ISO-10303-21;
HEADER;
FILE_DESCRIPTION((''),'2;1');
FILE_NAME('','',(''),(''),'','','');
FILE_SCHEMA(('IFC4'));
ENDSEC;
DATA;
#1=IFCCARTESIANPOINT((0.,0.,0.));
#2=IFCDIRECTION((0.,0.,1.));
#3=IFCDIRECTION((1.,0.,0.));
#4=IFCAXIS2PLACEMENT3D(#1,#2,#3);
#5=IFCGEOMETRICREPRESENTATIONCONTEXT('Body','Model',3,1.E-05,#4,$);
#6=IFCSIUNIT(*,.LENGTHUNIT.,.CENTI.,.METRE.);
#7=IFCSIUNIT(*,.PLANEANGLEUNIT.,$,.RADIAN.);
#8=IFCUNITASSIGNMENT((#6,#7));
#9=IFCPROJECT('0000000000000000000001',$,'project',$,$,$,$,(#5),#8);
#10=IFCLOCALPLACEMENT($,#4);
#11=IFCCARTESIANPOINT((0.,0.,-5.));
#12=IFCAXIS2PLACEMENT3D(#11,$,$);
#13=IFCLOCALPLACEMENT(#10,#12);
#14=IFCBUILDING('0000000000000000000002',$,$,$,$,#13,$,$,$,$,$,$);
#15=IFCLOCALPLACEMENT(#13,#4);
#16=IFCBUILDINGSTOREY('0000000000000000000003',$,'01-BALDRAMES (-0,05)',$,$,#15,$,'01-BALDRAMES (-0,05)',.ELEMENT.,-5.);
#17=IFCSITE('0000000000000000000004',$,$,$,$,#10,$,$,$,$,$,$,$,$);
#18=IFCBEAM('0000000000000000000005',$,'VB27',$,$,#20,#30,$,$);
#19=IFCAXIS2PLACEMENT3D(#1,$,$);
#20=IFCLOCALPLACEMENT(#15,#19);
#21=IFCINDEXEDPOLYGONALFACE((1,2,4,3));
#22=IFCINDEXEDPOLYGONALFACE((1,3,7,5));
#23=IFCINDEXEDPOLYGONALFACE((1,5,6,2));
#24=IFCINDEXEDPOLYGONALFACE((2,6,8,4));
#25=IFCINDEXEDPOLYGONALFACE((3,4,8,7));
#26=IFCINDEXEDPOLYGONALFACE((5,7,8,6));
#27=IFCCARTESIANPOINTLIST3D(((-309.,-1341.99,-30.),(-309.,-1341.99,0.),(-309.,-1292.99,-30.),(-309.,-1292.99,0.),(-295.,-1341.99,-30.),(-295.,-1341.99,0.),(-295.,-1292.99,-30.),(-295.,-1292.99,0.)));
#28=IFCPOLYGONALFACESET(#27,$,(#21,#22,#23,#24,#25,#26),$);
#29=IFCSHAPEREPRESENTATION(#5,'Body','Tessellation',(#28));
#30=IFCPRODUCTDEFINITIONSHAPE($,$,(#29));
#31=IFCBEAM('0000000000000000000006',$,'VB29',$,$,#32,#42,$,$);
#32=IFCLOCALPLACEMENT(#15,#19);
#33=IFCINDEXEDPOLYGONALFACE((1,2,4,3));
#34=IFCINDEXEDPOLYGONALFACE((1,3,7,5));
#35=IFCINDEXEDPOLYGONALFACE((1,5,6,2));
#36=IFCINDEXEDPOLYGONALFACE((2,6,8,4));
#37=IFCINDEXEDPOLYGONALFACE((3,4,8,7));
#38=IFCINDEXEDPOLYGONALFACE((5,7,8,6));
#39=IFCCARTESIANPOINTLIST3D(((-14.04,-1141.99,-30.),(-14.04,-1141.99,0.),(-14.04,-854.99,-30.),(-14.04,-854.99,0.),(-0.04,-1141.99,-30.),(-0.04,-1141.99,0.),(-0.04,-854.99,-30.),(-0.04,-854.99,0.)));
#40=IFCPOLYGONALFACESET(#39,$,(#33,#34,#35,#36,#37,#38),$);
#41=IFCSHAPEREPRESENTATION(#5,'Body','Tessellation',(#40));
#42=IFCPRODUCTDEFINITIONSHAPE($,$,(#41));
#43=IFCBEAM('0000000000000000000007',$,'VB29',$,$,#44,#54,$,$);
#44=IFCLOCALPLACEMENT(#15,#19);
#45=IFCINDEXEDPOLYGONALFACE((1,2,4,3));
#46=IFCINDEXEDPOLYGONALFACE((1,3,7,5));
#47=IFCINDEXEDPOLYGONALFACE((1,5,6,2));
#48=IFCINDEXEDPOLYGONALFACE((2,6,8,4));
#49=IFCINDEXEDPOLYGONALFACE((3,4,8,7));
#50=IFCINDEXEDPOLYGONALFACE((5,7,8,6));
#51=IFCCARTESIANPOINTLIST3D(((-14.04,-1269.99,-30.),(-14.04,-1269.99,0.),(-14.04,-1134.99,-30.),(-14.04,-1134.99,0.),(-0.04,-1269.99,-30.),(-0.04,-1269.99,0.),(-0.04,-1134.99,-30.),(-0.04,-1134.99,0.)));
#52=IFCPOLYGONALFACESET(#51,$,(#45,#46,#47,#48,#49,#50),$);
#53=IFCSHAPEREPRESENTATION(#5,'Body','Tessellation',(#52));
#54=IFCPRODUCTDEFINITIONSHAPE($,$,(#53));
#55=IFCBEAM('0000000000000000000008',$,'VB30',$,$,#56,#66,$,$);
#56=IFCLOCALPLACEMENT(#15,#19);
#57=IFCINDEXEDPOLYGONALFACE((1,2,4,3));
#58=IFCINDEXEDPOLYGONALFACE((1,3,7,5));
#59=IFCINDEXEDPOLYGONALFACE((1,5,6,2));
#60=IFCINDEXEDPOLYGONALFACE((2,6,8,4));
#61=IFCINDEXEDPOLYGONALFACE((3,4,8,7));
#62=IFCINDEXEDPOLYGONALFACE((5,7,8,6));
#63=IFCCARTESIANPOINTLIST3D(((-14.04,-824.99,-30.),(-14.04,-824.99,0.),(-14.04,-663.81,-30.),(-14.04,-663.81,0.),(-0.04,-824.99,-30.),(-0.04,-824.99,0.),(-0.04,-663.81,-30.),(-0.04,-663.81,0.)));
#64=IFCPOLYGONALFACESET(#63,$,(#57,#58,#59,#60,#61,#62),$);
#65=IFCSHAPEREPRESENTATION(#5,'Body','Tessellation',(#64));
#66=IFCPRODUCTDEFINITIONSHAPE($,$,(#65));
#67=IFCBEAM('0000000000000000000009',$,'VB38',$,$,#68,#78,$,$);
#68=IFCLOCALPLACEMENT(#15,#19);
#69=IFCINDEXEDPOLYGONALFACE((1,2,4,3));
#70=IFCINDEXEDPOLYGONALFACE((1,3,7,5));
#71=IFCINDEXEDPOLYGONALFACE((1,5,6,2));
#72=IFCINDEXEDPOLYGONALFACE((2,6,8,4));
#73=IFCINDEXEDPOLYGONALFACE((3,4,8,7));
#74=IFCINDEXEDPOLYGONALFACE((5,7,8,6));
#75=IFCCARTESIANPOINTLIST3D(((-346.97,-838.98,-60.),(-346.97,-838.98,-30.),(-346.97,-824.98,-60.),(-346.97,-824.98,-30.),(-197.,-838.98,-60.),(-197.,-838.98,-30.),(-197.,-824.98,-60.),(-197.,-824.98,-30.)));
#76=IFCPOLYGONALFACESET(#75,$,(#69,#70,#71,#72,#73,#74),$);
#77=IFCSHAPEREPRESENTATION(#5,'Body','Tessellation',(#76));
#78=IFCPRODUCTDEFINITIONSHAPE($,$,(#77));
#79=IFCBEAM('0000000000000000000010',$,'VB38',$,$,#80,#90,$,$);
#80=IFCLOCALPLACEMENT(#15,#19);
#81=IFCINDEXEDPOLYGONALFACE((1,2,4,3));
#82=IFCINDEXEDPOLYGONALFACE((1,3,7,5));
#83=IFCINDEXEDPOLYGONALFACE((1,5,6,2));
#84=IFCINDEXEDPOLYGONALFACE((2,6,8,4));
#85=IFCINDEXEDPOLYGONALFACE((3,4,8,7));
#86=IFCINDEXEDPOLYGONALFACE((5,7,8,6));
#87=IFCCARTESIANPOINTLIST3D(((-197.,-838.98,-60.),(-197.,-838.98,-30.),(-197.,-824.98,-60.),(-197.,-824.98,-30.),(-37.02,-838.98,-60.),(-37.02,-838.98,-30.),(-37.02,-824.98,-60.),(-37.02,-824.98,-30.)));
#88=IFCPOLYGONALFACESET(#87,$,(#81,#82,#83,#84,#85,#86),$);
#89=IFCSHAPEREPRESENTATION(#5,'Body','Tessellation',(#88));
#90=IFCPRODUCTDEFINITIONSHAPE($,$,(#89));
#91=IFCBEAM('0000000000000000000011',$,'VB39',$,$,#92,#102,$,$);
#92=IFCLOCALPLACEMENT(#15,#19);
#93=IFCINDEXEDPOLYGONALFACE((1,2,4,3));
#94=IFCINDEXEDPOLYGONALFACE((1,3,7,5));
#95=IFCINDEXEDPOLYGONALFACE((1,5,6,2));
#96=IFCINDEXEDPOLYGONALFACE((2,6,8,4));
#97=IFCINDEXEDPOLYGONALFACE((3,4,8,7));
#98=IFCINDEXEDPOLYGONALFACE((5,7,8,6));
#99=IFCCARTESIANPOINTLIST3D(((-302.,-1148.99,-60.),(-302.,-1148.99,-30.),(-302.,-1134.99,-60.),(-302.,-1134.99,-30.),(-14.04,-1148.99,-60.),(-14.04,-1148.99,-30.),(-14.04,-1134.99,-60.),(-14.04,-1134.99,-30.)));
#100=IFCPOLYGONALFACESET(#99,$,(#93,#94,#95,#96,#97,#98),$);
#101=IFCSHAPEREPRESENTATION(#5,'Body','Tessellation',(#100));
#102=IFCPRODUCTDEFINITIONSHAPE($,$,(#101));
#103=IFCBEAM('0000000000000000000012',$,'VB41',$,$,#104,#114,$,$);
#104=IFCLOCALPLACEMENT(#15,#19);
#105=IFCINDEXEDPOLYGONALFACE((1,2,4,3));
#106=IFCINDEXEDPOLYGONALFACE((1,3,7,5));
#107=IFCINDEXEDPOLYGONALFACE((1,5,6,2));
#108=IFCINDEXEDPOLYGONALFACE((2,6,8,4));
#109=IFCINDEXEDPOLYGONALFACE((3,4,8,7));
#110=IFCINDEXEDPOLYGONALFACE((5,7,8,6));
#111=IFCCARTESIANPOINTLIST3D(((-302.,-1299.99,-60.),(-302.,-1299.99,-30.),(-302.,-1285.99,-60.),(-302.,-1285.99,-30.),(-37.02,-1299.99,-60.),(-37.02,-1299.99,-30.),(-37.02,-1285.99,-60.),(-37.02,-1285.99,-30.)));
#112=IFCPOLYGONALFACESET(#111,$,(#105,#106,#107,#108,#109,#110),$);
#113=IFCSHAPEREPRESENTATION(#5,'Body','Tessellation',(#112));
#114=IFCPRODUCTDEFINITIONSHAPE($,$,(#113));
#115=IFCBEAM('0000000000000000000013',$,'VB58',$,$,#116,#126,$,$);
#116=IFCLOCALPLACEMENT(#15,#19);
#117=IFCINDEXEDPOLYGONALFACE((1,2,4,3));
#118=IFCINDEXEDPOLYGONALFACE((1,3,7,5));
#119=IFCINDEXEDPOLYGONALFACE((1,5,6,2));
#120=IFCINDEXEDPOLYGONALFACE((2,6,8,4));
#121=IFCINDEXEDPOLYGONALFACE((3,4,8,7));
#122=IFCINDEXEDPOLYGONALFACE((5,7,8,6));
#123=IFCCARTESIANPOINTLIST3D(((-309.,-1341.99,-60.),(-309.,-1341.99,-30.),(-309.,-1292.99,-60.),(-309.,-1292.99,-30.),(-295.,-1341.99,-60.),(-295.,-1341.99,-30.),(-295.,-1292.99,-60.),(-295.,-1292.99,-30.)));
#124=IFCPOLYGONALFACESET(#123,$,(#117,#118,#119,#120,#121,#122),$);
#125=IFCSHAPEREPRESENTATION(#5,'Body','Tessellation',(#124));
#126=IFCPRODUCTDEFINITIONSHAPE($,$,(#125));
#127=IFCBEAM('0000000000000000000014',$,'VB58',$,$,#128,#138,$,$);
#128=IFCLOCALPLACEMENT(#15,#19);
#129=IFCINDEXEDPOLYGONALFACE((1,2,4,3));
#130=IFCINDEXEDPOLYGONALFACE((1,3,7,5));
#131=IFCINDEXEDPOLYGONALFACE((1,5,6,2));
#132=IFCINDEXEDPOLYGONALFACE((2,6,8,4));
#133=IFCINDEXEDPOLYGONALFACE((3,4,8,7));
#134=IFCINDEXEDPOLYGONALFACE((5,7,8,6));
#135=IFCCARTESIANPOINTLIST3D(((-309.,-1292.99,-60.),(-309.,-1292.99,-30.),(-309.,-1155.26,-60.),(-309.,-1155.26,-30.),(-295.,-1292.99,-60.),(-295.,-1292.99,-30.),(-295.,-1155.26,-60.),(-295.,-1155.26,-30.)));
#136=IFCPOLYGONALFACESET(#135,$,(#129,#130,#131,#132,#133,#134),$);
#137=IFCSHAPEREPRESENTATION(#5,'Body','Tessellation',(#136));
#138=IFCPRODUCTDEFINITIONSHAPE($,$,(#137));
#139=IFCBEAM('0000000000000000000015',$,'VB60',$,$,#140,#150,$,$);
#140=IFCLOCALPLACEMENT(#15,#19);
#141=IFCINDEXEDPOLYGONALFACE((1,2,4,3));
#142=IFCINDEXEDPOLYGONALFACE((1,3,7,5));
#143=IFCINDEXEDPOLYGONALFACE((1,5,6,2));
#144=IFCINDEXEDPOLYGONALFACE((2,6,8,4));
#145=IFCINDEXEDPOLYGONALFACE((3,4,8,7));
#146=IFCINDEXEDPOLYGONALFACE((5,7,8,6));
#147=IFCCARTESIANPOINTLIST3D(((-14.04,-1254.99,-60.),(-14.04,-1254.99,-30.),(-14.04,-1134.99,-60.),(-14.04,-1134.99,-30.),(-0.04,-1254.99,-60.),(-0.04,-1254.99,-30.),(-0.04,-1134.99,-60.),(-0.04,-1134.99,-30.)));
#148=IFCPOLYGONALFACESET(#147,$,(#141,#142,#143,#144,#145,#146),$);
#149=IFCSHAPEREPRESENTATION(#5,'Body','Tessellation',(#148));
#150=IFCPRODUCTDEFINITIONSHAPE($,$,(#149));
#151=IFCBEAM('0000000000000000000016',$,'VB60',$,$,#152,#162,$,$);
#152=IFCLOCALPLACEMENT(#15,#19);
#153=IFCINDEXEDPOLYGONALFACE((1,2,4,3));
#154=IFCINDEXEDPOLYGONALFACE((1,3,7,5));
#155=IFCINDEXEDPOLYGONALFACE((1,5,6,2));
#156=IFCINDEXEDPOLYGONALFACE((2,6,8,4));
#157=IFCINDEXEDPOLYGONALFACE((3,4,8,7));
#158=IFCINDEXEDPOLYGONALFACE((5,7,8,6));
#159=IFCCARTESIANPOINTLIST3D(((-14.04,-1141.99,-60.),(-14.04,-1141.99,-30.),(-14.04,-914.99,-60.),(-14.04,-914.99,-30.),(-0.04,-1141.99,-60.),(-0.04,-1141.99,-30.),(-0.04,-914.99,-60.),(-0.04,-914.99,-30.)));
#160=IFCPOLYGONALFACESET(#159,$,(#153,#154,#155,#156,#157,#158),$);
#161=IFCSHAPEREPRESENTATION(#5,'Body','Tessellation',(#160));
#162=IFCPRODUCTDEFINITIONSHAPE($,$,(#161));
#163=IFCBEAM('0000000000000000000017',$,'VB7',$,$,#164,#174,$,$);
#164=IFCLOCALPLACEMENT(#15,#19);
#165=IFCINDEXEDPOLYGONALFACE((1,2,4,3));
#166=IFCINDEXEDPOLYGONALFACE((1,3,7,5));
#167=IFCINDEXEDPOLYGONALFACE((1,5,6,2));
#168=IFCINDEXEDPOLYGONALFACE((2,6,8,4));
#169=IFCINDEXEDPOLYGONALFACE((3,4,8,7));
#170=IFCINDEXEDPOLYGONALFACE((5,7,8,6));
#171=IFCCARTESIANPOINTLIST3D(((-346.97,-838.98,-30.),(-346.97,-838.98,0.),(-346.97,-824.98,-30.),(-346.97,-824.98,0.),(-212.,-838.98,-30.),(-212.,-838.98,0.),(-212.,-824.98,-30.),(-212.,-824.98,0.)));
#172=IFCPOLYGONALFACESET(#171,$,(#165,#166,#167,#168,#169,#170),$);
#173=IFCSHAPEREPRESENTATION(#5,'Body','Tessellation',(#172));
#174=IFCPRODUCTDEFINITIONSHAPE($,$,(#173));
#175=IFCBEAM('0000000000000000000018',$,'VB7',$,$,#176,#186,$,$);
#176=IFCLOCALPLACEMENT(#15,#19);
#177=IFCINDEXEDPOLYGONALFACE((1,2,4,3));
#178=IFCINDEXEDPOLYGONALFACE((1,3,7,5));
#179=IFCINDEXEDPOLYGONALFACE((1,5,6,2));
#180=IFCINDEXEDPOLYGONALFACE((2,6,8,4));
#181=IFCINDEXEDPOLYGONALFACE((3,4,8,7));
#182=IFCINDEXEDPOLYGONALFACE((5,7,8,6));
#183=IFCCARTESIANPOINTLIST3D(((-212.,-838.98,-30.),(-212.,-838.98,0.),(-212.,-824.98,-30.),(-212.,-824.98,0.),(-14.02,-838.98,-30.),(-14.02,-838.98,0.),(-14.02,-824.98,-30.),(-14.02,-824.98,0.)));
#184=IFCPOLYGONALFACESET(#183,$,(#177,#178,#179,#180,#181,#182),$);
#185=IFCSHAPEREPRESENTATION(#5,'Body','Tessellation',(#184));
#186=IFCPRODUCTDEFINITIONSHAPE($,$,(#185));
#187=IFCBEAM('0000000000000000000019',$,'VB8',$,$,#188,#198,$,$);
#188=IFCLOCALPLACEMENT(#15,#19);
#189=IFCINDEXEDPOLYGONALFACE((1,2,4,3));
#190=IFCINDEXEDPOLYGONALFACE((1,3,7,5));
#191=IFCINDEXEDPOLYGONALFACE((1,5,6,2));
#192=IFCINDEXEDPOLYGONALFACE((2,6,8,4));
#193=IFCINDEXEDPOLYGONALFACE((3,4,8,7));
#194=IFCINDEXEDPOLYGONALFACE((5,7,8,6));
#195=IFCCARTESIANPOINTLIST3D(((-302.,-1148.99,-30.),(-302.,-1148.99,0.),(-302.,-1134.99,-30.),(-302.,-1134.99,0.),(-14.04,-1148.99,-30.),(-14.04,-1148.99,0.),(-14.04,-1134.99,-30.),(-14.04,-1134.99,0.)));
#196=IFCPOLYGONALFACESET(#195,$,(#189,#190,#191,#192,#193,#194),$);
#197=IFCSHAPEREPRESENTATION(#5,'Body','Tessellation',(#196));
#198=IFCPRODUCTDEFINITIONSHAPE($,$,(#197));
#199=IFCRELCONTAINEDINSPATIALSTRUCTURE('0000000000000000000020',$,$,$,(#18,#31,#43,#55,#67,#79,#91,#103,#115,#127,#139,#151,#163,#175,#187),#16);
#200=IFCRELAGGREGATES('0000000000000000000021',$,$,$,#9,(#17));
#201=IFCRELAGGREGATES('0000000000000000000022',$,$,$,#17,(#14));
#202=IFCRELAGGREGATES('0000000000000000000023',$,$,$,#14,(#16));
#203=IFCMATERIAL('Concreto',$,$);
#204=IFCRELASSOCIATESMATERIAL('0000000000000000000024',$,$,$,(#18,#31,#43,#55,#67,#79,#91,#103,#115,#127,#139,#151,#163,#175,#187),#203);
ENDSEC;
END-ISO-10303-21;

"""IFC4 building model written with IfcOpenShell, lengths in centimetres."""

from ifc_helpers import new_model, si_unit, frame, origin_with_axes, origin_2d_with_axis, place, context, project, spatial, rectangle, extrude, material, element, save


model = new_model("IFC4")

# Units and contexts
model_context = context("Model", 3, precision=1e-05, world=origin_with_axes(), identifier="Body")
ifc_project = project(units=[si_unit("LENGTHUNIT", "METRE", prefix="CENTI"), si_unit("PLANEANGLEUNIT", "RADIAN")], contexts=[model_context])

# Site, building, storey
site_placement = place(None, origin_with_axes())
site = spatial("IfcSite", under=ifc_project, at=site_placement)
building_placement = place(site_placement, frame((0.0, 0.0, -5.0)))
building = spatial("IfcBuilding", under=site, at=building_placement)
storey_placement = place(building_placement, origin_with_axes())
storey = spatial("IfcBuildingStorey", under=building, at=storey_placement, Name="01-BALDRAMES (-0,05)", LongName="01-BALDRAMES (-0,05)", CompositionType="ELEMENT", Elevation=-5.0)

# Shared definitions
ifc_material = material(Name="Concreto")

# Beams
beam_1_placement = place(storey_placement, frame((-302.0, -1317.49, 0.0), z_axis=(0.0, 0.0, 1.0), x_axis=(1.0, 0.0, 0.0)))
element("IfcBeam", 1, at=beam_1_placement, inside=storey, material=ifc_material, Name="VB27", context=model_context, shape_type="SolidModel", body=[
    extrude(rectangle(XDim=14.0, YDim=30.0, at=origin_2d_with_axis()), frame((0.0, -24.5, -15.0), z_axis=(0.0, 1.0, 0.0), x_axis=(1.0, 0.0, 0.0)), (0.0, 0.0, 1.0), 49.0),
])
beam_2_placement = place(storey_placement, frame((-7.04, -998.49, 0.0), z_axis=(0.0, 0.0, 1.0), x_axis=(1.0, 0.0, 0.0)))
element("IfcBeam", 2, at=beam_2_placement, inside=storey, material=ifc_material, Name="VB29", context=model_context, shape_type="SolidModel", body=[
    extrude(rectangle(XDim=14.0, YDim=30.0, at=origin_2d_with_axis()), frame((0.0, -143.5, -15.0), z_axis=(0.0, 1.0, 0.0), x_axis=(1.0, 0.0, 0.0)), (0.0, 0.0, 1.0), 287.0),
])
beam_3_placement = place(storey_placement, frame((-7.04, -1202.49, 0.0), z_axis=(0.0, 0.0, 1.0), x_axis=(1.0, 0.0, 0.0)))
element("IfcBeam", 3, at=beam_3_placement, inside=storey, material=ifc_material, Name="VB29", context=model_context, shape_type="SolidModel", body=[
    extrude(rectangle(XDim=14.0, YDim=30.0, at=origin_2d_with_axis()), frame((0.0, -67.5, -15.0), z_axis=(0.0, 1.0, 0.0), x_axis=(1.0, 0.0, 0.0)), (0.0, 0.0, 1.0), 135.0),
])
beam_4_placement = place(storey_placement, frame((-7.04, -744.4, 0.0), z_axis=(0.0, 0.0, 1.0), x_axis=(1.0, 0.0, 0.0)))
element("IfcBeam", 4, at=beam_4_placement, inside=storey, material=ifc_material, Name="VB30", context=model_context, shape_type="SolidModel", body=[
    extrude(rectangle(XDim=14.0, YDim=30.0, at=origin_2d_with_axis()), frame((0.0, -80.59, -15.0), z_axis=(0.0, 1.0, 0.0), x_axis=(1.0, 0.0, 0.0)), (0.0, 0.0, 1.0), 161.18),
])
beam_5_placement = place(storey_placement, frame((-271.99, -831.98, -30.0), z_axis=(0.0, 0.0, 1.0), x_axis=(1.0, 0.0, 0.0)))
element("IfcBeam", 5, at=beam_5_placement, inside=storey, material=ifc_material, Name="VB38", context=model_context, shape_type="SolidModel", body=[
    extrude(rectangle(XDim=14.0, YDim=30.0, at=origin_2d_with_axis()), frame((-74.98, 0.0, -15.0), z_axis=(1.0, 0.0, 0.0), x_axis=(0.0, -1.0, 0.0)), (0.0, 0.0, 1.0), 149.97),
])
beam_6_placement = place(storey_placement, frame((-117.01, -831.98, -30.0), z_axis=(0.0, 0.0, 1.0), x_axis=(1.0, 0.0, 0.0)))
element("IfcBeam", 6, at=beam_6_placement, inside=storey, material=ifc_material, Name="VB38", context=model_context, shape_type="SolidModel", body=[
    extrude(rectangle(XDim=14.0, YDim=30.0, at=origin_2d_with_axis()), frame((-79.99, 0.0, -15.0), z_axis=(1.0, 0.0, 0.0), x_axis=(0.0, -1.0, 0.0)), (0.0, 0.0, 1.0), 159.98),
])
beam_7_placement = place(storey_placement, frame((-158.02, -1141.99, -30.0), z_axis=(0.0, 0.0, 1.0), x_axis=(1.0, 0.0, 0.0)))
element("IfcBeam", 7, at=beam_7_placement, inside=storey, material=ifc_material, Name="VB39", context=model_context, shape_type="SolidModel", body=[
    extrude(rectangle(XDim=14.0, YDim=30.0, at=origin_2d_with_axis()), frame((-143.98, 0.0, -15.0), z_axis=(1.0, 0.0, 0.0), x_axis=(0.0, -1.0, 0.0)), (0.0, 0.0, 1.0), 287.96),
])
beam_8_placement = place(storey_placement, frame((-169.51, -1292.99, -30.0), z_axis=(0.0, 0.0, 1.0), x_axis=(1.0, 0.0, 0.0)))
element("IfcBeam", 8, at=beam_8_placement, inside=storey, material=ifc_material, Name="VB41", context=model_context, shape_type="SolidModel", body=[
    extrude(rectangle(XDim=14.0, YDim=30.0, at=origin_2d_with_axis()), frame((-132.49, 0.0, -15.0), z_axis=(1.0, 0.0, 0.0), x_axis=(0.0, -1.0, 0.0)), (0.0, 0.0, 1.0), 264.98),
])
beam_9_placement = place(storey_placement, frame((-302.0, -1317.49, -30.0), z_axis=(0.0, 0.0, 1.0), x_axis=(1.0, 0.0, 0.0)))
element("IfcBeam", 9, at=beam_9_placement, inside=storey, material=ifc_material, Name="VB58", context=model_context, shape_type="SolidModel", body=[
    extrude(rectangle(XDim=14.0, YDim=30.0, at=origin_2d_with_axis()), frame((0.0, -24.5, -15.0), z_axis=(0.0, 1.0, 0.0), x_axis=(1.0, 0.0, 0.0)), (0.0, 0.0, 1.0), 49.0),
])
beam_10_placement = place(storey_placement, frame((-302.0, -1224.12, -30.0), z_axis=(0.0, 0.0, 1.0), x_axis=(1.0, 0.0, 0.0)))
element("IfcBeam", 10, at=beam_10_placement, inside=storey, material=ifc_material, Name="VB58", context=model_context, shape_type="SolidModel", body=[
    extrude(rectangle(XDim=14.0, YDim=30.0, at=origin_2d_with_axis()), frame((0.0, -68.87, -15.0), z_axis=(0.0, 1.0, 0.0), x_axis=(1.0, 0.0, 0.0)), (0.0, 0.0, 1.0), 137.73),
])
beam_11_placement = place(storey_placement, frame((-7.04, -1194.99, -30.0), z_axis=(0.0, 0.0, 1.0), x_axis=(1.0, 0.0, 0.0)))
element("IfcBeam", 11, at=beam_11_placement, inside=storey, material=ifc_material, Name="VB60", context=model_context, shape_type="SolidModel", body=[
    extrude(rectangle(XDim=14.0, YDim=30.0, at=origin_2d_with_axis()), frame((0.0, -60.0, -15.0), z_axis=(0.0, 1.0, 0.0), x_axis=(1.0, 0.0, 0.0)), (0.0, 0.0, 1.0), 120.0),
])
beam_12_placement = place(storey_placement, frame((-7.04, -1028.49, -30.0), z_axis=(0.0, 0.0, 1.0), x_axis=(1.0, 0.0, 0.0)))
element("IfcBeam", 12, at=beam_12_placement, inside=storey, material=ifc_material, Name="VB60", context=model_context, shape_type="SolidModel", body=[
    extrude(rectangle(XDim=14.0, YDim=30.0, at=origin_2d_with_axis()), frame((0.0, -113.5, -15.0), z_axis=(0.0, 1.0, 0.0), x_axis=(1.0, 0.0, 0.0)), (0.0, 0.0, 1.0), 227.0),
])
beam_13_placement = place(storey_placement, frame((-279.49, -831.98, 0.0), z_axis=(0.0, 0.0, 1.0), x_axis=(1.0, 0.0, 0.0)))
element("IfcBeam", 13, at=beam_13_placement, inside=storey, material=ifc_material, Name="VB7", context=model_context, shape_type="SolidModel", body=[
    extrude(rectangle(XDim=14.0, YDim=30.0, at=origin_2d_with_axis()), frame((-67.48, 0.0, -15.0), z_axis=(1.0, 0.0, 0.0), x_axis=(0.0, -1.0, 0.0)), (0.0, 0.0, 1.0), 134.97),
])
beam_14_placement = place(storey_placement, frame((-113.01, -831.98, 0.0), z_axis=(0.0, 0.0, 1.0), x_axis=(1.0, 0.0, 0.0)))
element("IfcBeam", 14, at=beam_14_placement, inside=storey, material=ifc_material, Name="VB7", context=model_context, shape_type="SolidModel", body=[
    extrude(rectangle(XDim=14.0, YDim=30.0, at=origin_2d_with_axis()), frame((-98.99, 0.0, -15.0), z_axis=(1.0, 0.0, 0.0), x_axis=(0.0, -1.0, 0.0)), (0.0, 0.0, 1.0), 197.98),
])
beam_15_placement = place(storey_placement, frame((-158.02, -1141.99, 0.0), z_axis=(0.0, 0.0, 1.0), x_axis=(1.0, 0.0, 0.0)))
element("IfcBeam", 15, at=beam_15_placement, inside=storey, material=ifc_material, Name="VB8", context=model_context, shape_type="SolidModel", body=[
    extrude(rectangle(XDim=14.0, YDim=30.0, at=origin_2d_with_axis()), frame((-143.98, 0.0, -15.0), z_axis=(1.0, 0.0, 0.0), x_axis=(0.0, -1.0, 0.0)), (0.0, 0.0, 1.0), 287.96),
])

save(model, "model.ifc")
